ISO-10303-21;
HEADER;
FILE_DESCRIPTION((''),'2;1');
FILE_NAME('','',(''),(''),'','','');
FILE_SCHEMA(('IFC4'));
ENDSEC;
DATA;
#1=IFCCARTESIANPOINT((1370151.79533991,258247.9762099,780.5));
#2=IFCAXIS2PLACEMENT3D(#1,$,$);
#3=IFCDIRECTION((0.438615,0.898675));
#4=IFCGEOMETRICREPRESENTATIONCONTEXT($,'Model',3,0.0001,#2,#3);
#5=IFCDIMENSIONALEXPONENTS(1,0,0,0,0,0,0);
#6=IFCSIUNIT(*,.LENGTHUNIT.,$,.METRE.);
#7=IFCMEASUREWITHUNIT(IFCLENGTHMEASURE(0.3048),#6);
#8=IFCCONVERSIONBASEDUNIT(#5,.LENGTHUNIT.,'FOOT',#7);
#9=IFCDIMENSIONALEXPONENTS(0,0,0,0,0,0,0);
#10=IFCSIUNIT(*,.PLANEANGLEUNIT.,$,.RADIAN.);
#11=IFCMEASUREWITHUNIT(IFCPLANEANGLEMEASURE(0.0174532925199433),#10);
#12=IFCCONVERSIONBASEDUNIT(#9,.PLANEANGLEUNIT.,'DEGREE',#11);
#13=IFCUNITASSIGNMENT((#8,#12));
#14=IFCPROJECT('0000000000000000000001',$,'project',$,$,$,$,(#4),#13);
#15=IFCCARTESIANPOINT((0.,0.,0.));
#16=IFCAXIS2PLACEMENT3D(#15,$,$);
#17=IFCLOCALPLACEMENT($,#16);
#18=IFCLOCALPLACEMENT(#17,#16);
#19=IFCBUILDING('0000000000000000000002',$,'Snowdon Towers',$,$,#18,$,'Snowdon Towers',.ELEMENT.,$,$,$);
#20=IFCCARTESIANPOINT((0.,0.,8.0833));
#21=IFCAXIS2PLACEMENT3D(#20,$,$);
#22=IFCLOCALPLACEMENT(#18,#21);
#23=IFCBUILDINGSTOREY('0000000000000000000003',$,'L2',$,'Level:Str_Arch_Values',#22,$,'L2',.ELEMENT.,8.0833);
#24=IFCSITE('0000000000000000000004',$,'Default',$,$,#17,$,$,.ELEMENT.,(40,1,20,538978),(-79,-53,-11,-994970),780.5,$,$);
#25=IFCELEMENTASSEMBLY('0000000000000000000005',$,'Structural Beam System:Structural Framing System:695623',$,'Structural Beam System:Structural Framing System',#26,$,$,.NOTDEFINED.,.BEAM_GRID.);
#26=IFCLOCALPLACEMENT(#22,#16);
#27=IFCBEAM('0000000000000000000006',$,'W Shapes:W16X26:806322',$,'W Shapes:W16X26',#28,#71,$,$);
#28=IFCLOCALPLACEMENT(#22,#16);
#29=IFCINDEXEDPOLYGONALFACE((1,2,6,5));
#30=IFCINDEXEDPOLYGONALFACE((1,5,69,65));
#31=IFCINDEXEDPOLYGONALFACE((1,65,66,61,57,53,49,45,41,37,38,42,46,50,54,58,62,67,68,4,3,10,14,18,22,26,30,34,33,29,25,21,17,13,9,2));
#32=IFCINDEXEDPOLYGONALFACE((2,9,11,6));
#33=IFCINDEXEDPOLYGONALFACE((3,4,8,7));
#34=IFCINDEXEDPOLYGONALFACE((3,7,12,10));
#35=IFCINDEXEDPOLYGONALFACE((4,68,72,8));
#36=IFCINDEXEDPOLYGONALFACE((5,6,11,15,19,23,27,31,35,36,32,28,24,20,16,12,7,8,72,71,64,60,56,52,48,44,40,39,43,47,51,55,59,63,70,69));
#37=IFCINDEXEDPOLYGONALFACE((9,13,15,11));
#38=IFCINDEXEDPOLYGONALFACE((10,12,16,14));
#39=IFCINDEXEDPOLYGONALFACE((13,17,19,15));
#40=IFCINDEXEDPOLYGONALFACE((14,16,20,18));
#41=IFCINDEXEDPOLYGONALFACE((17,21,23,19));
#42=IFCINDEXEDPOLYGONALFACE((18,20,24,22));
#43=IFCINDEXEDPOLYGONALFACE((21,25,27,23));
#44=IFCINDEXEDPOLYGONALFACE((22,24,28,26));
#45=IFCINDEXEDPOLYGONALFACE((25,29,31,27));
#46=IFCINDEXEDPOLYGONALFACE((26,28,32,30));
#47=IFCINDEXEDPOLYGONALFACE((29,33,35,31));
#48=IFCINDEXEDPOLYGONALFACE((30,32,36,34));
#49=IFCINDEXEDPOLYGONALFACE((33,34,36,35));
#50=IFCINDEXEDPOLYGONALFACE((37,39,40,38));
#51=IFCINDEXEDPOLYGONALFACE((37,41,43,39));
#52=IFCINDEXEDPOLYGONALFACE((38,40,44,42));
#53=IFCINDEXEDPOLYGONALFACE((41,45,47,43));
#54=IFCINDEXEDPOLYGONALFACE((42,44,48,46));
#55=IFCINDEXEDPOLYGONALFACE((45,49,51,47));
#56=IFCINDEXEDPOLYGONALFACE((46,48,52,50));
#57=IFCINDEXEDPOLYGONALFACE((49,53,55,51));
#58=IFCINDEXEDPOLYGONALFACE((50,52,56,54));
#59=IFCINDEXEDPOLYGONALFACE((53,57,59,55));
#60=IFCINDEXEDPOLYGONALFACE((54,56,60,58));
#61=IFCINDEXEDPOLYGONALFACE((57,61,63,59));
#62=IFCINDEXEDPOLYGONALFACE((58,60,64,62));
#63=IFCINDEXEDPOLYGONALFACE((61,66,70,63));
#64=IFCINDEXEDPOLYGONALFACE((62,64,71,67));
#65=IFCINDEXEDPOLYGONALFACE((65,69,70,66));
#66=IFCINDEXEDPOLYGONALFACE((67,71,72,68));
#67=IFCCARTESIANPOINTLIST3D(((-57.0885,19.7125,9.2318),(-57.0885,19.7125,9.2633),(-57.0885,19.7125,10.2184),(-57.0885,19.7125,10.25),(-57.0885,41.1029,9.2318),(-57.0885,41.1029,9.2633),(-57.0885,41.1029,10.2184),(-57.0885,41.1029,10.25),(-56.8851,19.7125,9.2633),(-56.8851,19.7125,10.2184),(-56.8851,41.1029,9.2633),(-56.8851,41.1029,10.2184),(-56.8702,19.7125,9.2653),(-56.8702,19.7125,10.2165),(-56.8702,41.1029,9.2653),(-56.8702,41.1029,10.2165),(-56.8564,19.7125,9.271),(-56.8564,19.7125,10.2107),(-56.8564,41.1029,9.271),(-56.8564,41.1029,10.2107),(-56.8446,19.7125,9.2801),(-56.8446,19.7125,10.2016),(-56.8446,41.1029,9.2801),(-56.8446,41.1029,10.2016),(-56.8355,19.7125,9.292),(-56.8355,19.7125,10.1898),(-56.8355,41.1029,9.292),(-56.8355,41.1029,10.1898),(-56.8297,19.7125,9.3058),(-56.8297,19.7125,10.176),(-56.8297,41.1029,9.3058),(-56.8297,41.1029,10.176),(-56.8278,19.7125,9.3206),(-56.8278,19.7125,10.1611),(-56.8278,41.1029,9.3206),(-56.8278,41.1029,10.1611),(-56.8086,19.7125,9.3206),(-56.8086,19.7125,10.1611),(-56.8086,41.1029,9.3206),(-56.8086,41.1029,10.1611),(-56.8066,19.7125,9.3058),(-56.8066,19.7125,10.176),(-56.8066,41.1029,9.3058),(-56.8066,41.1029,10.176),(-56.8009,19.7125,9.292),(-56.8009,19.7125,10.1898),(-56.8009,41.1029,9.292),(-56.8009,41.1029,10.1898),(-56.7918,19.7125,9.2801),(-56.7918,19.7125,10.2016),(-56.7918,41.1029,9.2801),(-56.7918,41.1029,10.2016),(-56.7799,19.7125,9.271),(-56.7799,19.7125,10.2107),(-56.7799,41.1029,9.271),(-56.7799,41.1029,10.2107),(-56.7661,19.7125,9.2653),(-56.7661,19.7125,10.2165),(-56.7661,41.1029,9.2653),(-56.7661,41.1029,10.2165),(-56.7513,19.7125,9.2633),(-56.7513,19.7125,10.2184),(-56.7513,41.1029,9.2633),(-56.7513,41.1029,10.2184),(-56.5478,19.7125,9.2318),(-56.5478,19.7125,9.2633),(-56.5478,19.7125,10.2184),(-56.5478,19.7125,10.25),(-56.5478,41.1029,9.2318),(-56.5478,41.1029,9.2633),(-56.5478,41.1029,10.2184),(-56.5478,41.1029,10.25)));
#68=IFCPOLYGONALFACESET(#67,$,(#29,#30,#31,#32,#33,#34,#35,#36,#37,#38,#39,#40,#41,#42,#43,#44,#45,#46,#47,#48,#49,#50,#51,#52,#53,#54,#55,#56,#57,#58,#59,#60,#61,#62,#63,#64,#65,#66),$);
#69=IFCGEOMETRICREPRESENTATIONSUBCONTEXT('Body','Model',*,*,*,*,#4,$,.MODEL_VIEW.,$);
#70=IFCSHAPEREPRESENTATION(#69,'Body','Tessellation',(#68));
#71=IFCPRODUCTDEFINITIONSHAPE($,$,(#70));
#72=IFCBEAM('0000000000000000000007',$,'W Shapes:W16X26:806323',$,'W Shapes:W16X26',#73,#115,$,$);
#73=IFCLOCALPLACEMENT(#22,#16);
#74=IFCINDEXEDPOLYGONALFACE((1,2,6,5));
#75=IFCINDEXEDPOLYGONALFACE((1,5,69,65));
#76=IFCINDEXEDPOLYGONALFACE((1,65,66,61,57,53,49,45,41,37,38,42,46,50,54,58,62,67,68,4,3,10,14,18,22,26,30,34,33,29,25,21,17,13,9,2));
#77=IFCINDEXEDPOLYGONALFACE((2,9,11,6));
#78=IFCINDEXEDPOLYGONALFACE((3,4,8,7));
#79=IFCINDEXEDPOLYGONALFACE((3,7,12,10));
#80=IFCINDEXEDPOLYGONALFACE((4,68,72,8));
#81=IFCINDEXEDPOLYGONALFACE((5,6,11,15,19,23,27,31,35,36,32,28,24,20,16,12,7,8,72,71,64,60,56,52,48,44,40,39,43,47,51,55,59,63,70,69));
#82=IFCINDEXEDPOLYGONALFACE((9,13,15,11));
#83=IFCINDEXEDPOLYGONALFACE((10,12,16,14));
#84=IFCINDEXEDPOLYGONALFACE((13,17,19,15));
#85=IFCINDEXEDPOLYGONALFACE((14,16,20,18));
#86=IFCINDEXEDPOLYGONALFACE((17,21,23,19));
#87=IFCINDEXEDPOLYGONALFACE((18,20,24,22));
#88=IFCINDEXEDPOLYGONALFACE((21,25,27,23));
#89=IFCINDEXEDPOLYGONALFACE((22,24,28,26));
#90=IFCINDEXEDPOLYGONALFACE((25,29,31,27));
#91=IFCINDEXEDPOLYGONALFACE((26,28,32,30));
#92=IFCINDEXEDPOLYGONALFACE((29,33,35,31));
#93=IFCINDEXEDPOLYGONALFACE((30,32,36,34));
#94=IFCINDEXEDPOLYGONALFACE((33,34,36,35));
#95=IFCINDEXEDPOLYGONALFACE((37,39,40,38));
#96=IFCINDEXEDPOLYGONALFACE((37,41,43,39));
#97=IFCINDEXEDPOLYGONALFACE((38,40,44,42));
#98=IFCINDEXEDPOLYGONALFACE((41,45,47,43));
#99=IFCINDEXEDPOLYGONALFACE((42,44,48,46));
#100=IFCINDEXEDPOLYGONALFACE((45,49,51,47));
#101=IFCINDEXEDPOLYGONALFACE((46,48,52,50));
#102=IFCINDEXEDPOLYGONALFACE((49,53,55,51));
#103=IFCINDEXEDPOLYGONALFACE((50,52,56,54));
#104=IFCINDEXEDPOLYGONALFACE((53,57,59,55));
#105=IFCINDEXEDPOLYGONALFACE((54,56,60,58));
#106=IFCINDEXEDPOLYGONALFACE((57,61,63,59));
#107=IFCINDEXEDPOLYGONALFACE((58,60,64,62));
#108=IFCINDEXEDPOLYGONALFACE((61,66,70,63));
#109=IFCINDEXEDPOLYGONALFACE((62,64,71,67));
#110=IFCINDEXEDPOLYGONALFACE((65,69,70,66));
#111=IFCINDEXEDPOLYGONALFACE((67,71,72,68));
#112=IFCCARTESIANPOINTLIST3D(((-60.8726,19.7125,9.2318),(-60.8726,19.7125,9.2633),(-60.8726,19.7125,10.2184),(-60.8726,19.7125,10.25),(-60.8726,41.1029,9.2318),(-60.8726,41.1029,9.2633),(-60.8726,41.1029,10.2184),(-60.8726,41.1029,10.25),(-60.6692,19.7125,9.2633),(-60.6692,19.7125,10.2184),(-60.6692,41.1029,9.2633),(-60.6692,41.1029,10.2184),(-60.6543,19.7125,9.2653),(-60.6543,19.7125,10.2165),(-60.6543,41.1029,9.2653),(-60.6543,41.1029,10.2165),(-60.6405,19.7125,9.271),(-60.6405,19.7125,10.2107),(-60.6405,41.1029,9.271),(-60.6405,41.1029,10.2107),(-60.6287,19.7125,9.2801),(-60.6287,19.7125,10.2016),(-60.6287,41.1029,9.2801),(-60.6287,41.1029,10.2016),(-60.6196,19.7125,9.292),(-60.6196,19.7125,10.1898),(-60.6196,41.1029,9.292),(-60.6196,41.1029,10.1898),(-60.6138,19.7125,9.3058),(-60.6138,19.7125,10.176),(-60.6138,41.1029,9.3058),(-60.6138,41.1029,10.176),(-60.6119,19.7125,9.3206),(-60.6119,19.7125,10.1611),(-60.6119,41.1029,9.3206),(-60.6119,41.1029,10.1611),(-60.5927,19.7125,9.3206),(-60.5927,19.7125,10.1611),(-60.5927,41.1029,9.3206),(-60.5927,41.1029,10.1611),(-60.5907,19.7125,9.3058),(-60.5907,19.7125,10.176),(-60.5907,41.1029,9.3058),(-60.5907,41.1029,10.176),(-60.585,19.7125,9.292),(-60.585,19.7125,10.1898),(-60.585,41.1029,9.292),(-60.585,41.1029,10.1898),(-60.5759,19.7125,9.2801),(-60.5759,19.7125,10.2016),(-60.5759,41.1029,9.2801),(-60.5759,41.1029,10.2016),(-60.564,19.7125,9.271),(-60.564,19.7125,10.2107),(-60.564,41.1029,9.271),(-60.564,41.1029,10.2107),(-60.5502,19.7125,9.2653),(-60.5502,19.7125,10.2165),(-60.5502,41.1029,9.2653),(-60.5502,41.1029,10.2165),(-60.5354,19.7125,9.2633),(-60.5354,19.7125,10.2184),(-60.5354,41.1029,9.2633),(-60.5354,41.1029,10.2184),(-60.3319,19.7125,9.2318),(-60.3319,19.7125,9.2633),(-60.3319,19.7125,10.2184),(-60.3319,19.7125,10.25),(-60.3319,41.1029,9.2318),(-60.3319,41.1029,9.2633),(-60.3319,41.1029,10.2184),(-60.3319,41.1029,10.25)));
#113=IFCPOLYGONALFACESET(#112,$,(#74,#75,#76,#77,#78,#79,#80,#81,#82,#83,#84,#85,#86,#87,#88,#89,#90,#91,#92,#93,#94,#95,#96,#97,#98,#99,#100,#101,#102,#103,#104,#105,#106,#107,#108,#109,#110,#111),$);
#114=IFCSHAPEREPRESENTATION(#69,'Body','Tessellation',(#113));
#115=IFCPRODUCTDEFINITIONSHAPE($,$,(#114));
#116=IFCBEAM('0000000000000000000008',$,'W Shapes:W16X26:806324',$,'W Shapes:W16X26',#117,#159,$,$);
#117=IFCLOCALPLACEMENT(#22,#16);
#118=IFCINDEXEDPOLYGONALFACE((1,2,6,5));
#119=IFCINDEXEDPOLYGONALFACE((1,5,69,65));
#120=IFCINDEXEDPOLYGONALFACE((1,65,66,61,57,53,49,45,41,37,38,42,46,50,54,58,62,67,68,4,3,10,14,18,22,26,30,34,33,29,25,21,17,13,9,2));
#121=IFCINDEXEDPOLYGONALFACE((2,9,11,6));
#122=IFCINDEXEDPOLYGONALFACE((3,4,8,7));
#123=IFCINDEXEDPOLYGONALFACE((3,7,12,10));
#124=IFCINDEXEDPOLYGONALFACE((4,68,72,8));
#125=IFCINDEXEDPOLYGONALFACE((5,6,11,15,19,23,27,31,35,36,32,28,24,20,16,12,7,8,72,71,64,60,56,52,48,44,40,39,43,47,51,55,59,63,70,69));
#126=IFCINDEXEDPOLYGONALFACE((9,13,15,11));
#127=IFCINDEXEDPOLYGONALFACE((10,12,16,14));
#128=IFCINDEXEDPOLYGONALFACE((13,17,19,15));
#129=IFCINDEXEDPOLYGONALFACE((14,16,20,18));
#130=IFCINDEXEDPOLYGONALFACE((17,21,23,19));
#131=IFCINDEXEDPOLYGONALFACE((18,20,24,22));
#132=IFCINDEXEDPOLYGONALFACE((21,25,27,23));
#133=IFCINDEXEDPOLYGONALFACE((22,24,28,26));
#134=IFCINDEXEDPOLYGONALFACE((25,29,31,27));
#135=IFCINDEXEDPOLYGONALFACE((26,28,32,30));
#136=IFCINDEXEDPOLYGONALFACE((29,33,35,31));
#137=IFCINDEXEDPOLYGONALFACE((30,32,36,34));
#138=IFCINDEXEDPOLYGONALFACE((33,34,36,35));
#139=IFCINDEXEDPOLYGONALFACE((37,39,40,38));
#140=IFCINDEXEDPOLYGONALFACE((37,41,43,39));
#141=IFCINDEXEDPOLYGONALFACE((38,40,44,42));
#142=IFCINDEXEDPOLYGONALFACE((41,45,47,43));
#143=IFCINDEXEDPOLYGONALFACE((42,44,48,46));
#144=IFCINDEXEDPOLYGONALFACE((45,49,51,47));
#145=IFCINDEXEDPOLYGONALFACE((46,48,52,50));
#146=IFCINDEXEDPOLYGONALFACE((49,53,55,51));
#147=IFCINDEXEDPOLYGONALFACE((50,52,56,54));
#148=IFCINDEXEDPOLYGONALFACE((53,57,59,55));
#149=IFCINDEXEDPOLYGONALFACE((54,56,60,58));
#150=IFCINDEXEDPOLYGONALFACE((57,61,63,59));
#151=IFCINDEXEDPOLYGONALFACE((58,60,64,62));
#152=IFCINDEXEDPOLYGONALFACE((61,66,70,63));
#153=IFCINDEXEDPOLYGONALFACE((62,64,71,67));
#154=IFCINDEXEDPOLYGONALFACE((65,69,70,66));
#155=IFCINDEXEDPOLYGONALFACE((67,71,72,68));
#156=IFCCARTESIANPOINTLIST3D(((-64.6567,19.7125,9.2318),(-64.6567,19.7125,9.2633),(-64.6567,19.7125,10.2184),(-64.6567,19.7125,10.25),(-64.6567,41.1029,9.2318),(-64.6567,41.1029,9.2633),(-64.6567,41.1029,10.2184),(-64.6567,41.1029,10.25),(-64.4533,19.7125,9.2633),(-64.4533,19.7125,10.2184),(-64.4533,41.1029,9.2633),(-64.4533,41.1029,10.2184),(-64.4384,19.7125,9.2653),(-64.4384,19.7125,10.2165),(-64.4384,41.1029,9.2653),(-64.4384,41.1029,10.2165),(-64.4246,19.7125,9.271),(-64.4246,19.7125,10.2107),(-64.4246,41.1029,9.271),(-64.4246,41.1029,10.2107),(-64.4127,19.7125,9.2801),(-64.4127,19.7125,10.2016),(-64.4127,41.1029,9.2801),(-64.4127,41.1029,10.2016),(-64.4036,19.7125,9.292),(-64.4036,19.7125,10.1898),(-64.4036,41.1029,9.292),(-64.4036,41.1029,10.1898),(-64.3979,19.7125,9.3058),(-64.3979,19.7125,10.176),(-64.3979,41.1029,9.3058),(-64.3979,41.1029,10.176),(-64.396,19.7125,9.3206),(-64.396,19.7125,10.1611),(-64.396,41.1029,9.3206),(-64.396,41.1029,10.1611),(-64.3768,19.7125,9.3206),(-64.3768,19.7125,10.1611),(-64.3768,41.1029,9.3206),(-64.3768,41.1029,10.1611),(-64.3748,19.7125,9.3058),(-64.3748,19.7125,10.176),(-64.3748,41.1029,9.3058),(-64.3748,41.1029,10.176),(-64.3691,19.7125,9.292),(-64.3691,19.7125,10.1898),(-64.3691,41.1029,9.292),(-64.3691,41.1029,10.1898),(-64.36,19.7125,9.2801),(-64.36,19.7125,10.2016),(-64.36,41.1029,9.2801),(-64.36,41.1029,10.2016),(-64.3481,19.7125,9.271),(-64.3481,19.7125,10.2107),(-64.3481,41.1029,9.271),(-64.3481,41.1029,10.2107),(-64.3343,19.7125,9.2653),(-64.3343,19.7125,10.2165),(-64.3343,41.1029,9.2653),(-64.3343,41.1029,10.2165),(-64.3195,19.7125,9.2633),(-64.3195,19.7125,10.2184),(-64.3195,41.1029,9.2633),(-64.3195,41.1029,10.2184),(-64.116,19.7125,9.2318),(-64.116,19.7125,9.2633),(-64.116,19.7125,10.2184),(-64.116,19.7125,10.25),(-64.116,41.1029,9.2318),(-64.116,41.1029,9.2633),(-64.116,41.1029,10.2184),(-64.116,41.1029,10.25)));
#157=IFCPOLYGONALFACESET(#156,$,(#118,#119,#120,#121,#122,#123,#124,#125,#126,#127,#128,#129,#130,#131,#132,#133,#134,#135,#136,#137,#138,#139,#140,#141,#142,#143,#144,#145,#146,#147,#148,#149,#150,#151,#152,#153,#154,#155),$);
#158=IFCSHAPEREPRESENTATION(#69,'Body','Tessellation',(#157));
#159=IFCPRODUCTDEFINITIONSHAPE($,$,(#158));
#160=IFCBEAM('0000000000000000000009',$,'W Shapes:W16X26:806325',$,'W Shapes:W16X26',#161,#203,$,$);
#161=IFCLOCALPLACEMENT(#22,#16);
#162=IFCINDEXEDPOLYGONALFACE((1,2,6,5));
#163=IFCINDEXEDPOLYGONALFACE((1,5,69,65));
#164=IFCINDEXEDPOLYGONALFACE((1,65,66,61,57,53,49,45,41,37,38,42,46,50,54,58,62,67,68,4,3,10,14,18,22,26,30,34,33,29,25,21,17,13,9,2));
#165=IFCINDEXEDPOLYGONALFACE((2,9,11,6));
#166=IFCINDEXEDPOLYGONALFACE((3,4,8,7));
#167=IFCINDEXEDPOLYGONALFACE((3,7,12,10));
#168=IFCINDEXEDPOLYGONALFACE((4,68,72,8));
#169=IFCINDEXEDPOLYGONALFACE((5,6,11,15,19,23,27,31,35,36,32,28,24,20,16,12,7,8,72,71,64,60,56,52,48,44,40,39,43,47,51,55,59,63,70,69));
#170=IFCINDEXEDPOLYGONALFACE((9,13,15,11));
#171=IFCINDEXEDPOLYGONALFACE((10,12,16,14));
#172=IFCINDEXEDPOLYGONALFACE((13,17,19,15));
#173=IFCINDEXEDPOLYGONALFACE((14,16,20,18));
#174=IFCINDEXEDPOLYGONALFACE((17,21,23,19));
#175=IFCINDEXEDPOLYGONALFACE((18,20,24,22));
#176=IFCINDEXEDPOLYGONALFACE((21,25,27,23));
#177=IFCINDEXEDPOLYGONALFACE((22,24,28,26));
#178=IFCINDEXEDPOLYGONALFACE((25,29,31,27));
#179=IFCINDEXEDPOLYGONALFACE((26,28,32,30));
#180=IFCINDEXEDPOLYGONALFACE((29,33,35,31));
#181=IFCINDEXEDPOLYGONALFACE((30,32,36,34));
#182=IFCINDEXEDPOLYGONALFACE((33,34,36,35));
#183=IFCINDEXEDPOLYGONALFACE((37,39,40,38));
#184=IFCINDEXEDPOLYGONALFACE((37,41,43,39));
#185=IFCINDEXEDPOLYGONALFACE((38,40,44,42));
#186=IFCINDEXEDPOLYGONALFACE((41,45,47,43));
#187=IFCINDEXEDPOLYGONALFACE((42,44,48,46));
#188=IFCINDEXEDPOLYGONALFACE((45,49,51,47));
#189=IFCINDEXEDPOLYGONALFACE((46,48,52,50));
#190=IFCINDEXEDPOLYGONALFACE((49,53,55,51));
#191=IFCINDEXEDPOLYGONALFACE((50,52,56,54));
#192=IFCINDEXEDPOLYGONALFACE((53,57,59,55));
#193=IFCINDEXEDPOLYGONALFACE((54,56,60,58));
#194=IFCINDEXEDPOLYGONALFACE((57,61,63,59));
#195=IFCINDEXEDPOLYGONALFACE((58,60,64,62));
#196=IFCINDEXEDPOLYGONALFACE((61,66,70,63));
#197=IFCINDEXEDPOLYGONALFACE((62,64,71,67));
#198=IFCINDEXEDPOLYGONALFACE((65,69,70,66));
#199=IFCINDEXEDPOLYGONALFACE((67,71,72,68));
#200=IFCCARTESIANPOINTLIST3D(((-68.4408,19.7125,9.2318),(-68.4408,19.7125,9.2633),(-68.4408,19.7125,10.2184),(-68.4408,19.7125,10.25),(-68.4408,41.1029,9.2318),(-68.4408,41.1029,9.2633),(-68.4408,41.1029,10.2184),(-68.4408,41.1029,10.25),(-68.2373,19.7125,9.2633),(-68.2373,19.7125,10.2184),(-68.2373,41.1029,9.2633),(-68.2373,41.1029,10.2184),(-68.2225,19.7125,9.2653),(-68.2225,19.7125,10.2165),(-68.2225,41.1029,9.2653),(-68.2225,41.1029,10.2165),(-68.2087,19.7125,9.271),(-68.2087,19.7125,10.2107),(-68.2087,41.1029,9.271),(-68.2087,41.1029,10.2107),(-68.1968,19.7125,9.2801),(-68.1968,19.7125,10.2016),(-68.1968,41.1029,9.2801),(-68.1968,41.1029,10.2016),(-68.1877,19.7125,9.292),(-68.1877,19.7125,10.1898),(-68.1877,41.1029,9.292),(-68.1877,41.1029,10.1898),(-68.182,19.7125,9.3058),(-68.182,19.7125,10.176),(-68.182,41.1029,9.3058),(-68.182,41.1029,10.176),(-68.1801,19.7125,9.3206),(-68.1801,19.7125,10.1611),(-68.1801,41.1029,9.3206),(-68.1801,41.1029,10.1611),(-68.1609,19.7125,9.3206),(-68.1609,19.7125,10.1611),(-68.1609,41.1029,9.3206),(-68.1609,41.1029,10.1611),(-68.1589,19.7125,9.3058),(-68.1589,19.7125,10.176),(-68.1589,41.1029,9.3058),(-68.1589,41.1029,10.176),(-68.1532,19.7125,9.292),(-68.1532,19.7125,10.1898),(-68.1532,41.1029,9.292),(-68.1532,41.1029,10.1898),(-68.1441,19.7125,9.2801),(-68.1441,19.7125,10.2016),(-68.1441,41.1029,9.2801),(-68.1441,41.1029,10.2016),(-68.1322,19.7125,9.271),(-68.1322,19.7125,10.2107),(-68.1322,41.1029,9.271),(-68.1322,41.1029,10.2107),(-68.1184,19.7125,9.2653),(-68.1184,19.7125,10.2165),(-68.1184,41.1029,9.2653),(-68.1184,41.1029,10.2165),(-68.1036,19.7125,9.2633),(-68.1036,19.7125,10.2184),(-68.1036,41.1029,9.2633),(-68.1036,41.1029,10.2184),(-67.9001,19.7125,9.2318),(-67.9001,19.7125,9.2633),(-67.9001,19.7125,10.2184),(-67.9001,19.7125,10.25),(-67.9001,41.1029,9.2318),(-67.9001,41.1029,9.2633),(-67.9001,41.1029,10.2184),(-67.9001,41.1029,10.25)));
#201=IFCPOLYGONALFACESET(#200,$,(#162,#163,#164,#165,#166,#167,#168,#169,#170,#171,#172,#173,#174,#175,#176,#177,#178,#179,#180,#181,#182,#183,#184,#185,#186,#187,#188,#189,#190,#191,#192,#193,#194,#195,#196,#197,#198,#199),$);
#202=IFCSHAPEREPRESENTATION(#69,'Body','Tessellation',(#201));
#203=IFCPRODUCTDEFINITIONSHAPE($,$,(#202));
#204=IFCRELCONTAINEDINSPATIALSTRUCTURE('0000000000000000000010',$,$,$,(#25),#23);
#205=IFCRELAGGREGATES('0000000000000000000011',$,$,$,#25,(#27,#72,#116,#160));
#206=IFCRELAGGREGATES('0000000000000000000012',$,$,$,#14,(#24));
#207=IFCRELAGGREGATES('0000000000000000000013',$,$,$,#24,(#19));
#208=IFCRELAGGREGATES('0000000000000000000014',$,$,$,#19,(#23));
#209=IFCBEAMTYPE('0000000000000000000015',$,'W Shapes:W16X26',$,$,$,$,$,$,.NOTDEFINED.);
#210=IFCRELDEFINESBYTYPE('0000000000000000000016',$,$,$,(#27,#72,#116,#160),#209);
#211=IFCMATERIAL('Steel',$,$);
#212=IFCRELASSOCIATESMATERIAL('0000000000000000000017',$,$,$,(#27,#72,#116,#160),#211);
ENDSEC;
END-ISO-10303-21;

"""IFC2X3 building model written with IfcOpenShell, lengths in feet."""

from ifc_helpers import new_model, entity, si_unit, converted_unit, direction, frame, frame_2d, origin, place, context, subcontext, project, spatial, i_section, extrude, material, type_object, element, aggregate, save


model = new_model("IFC2X3")

# Units and contexts
model_context = context("Model", 3, precision=0.0001, world=frame((1370151.79533991, 258247.9762099, 780.5)), true_north=direction((0.438615, 0.898675)))
body_context = subcontext(model_context, "Body", "Model", "MODEL_VIEW")
ifc_project = project(units=[converted_unit("LENGTHUNIT", "FOOT", entity("IfcLengthMeasure", 0.3048), si_unit("LENGTHUNIT", "METRE"), dimensions=[1, 0, 0, 0, 0, 0, 0]), converted_unit("PLANEANGLEUNIT", "DEGREE", entity("IfcPlaneAngleMeasure", 0.0174532925199433), si_unit("PLANEANGLEUNIT", "RADIAN"), dimensions=[0, 0, 0, 0, 0, 0, 0])], contexts=[model_context])

# Site, building, storey
site_placement = place(None, origin())
site = spatial("IfcSite", under=ifc_project, at=site_placement, Name="Default", CompositionType="ELEMENT", RefLatitude=(40, 1, 20, 538978), RefLongitude=(-79, -53, -11, -994970), RefElevation=780.5)
building_placement = place(site_placement, origin())
building = spatial("IfcBuilding", under=site, at=building_placement, Name="Snowdon Towers", LongName="Snowdon Towers", CompositionType="ELEMENT")
storey_placement = place(building_placement, frame((0.0, 0.0, 8.0833)))
storey = spatial("IfcBuildingStorey", under=building, at=storey_placement, Name="L2", ObjectType="Level:Str_Arch_Values", LongName="L2", CompositionType="ELEMENT", Elevation=8.0833)

# Shared definitions
ifc_material = material(Name="Steel")

# Element assembly, beams
assembly_1_placement = place(storey_placement, origin())
assembly_1 = element("IfcElementAssembly", 1, at=assembly_1_placement, inside=storey, Name="Structural Beam System:Structural Framing System:695623", ObjectType="Structural Beam System:Structural Framing System", AssemblyPlace="NOTDEFINED", PredefinedType="BEAM_GRID")
beam_type_1 = type_object("IfcBeamType", Name="W Shapes:W16X26", PredefinedType="NOTDEFINED")
beam_1_placement = place(assembly_1_placement, frame((-56.8182, 41.4583, 10.25), z_axis=(0.0, 0.0, 1.0), x_axis=(0.0, -1.0, 0.0)))
beam_1 = element("IfcBeam", 2, at=beam_1_placement, type_object=beam_type_1, material=ifc_material, Name="W Shapes:W16X26:806322", ObjectType="W Shapes:W16X26", context=body_context, shape_type="SweptSolid", body=[
    extrude(i_section(OverallWidth=0.5407, OverallDepth=1.0182, WebThickness=0.0192, FlangeThickness=0.0316, FilletRadius=0.0573, at=frame_2d((0.0, 0.0), x_axis=(0.0, 1.0))), frame((0.3554, 0.0, -0.5091), z_axis=(1.0, 0.0, 0.0), x_axis=(0.0, 0.0, -1.0)), (0.0, 0.0, 1.0), 21.3904),
])
beam_2_placement = place(assembly_1_placement, frame((-60.6023, 41.4583, 10.25), z_axis=(0.0, 0.0, 1.0), x_axis=(0.0, -1.0, 0.0)))
beam_2 = element("IfcBeam", 3, at=beam_2_placement, type_object=beam_type_1, material=ifc_material, Name="W Shapes:W16X26:806323", ObjectType="W Shapes:W16X26", context=body_context, shape_type="SweptSolid", body=[
    extrude(i_section(OverallWidth=0.5407, OverallDepth=1.0182, WebThickness=0.0192, FlangeThickness=0.0316, FilletRadius=0.0573, at=frame_2d((0.0, 0.0), x_axis=(0.0, 1.0))), frame((0.3554, 0.0, -0.5091), z_axis=(1.0, 0.0, 0.0), x_axis=(0.0, 0.0, -1.0)), (0.0, 0.0, 1.0), 21.3904),
])
beam_3_placement = place(assembly_1_placement, frame((-64.3864, 41.4583, 10.25), z_axis=(0.0, 0.0, 1.0), x_axis=(0.0, -1.0, 0.0)))
beam_3 = element("IfcBeam", 4, at=beam_3_placement, type_object=beam_type_1, material=ifc_material, Name="W Shapes:W16X26:806324", ObjectType="W Shapes:W16X26", context=body_context, shape_type="SweptSolid", body=[
    extrude(i_section(OverallWidth=0.5407, OverallDepth=1.0182, WebThickness=0.0192, FlangeThickness=0.0316, FilletRadius=0.0573, at=frame_2d((0.0, 0.0), x_axis=(0.0, 1.0))), frame((0.3554, 0.0, -0.5091), z_axis=(1.0, 0.0, 0.0), x_axis=(0.0, 0.0, -1.0)), (0.0, 0.0, 1.0), 21.3904),
])
beam_4_placement = place(assembly_1_placement, frame((-68.1705, 41.4583, 10.25), z_axis=(0.0, 0.0, 1.0), x_axis=(0.0, -1.0, 0.0)))
beam_4 = element("IfcBeam", 5, at=beam_4_placement, type_object=beam_type_1, material=ifc_material, Name="W Shapes:W16X26:806325", ObjectType="W Shapes:W16X26", context=body_context, shape_type="SweptSolid", body=[
    extrude(i_section(OverallWidth=0.5407, OverallDepth=1.0182, WebThickness=0.0192, FlangeThickness=0.0316, FilletRadius=0.0573, at=frame_2d((0.0, 0.0), x_axis=(0.0, 1.0))), frame((0.3554, 0.0, -0.5091), z_axis=(1.0, 0.0, 0.0), x_axis=(0.0, 0.0, -1.0)), (0.0, 0.0, 1.0), 21.3904),
])
aggregate(assembly_1, [beam_1, beam_2, beam_3, beam_4])

save(model, "model.ifc")
